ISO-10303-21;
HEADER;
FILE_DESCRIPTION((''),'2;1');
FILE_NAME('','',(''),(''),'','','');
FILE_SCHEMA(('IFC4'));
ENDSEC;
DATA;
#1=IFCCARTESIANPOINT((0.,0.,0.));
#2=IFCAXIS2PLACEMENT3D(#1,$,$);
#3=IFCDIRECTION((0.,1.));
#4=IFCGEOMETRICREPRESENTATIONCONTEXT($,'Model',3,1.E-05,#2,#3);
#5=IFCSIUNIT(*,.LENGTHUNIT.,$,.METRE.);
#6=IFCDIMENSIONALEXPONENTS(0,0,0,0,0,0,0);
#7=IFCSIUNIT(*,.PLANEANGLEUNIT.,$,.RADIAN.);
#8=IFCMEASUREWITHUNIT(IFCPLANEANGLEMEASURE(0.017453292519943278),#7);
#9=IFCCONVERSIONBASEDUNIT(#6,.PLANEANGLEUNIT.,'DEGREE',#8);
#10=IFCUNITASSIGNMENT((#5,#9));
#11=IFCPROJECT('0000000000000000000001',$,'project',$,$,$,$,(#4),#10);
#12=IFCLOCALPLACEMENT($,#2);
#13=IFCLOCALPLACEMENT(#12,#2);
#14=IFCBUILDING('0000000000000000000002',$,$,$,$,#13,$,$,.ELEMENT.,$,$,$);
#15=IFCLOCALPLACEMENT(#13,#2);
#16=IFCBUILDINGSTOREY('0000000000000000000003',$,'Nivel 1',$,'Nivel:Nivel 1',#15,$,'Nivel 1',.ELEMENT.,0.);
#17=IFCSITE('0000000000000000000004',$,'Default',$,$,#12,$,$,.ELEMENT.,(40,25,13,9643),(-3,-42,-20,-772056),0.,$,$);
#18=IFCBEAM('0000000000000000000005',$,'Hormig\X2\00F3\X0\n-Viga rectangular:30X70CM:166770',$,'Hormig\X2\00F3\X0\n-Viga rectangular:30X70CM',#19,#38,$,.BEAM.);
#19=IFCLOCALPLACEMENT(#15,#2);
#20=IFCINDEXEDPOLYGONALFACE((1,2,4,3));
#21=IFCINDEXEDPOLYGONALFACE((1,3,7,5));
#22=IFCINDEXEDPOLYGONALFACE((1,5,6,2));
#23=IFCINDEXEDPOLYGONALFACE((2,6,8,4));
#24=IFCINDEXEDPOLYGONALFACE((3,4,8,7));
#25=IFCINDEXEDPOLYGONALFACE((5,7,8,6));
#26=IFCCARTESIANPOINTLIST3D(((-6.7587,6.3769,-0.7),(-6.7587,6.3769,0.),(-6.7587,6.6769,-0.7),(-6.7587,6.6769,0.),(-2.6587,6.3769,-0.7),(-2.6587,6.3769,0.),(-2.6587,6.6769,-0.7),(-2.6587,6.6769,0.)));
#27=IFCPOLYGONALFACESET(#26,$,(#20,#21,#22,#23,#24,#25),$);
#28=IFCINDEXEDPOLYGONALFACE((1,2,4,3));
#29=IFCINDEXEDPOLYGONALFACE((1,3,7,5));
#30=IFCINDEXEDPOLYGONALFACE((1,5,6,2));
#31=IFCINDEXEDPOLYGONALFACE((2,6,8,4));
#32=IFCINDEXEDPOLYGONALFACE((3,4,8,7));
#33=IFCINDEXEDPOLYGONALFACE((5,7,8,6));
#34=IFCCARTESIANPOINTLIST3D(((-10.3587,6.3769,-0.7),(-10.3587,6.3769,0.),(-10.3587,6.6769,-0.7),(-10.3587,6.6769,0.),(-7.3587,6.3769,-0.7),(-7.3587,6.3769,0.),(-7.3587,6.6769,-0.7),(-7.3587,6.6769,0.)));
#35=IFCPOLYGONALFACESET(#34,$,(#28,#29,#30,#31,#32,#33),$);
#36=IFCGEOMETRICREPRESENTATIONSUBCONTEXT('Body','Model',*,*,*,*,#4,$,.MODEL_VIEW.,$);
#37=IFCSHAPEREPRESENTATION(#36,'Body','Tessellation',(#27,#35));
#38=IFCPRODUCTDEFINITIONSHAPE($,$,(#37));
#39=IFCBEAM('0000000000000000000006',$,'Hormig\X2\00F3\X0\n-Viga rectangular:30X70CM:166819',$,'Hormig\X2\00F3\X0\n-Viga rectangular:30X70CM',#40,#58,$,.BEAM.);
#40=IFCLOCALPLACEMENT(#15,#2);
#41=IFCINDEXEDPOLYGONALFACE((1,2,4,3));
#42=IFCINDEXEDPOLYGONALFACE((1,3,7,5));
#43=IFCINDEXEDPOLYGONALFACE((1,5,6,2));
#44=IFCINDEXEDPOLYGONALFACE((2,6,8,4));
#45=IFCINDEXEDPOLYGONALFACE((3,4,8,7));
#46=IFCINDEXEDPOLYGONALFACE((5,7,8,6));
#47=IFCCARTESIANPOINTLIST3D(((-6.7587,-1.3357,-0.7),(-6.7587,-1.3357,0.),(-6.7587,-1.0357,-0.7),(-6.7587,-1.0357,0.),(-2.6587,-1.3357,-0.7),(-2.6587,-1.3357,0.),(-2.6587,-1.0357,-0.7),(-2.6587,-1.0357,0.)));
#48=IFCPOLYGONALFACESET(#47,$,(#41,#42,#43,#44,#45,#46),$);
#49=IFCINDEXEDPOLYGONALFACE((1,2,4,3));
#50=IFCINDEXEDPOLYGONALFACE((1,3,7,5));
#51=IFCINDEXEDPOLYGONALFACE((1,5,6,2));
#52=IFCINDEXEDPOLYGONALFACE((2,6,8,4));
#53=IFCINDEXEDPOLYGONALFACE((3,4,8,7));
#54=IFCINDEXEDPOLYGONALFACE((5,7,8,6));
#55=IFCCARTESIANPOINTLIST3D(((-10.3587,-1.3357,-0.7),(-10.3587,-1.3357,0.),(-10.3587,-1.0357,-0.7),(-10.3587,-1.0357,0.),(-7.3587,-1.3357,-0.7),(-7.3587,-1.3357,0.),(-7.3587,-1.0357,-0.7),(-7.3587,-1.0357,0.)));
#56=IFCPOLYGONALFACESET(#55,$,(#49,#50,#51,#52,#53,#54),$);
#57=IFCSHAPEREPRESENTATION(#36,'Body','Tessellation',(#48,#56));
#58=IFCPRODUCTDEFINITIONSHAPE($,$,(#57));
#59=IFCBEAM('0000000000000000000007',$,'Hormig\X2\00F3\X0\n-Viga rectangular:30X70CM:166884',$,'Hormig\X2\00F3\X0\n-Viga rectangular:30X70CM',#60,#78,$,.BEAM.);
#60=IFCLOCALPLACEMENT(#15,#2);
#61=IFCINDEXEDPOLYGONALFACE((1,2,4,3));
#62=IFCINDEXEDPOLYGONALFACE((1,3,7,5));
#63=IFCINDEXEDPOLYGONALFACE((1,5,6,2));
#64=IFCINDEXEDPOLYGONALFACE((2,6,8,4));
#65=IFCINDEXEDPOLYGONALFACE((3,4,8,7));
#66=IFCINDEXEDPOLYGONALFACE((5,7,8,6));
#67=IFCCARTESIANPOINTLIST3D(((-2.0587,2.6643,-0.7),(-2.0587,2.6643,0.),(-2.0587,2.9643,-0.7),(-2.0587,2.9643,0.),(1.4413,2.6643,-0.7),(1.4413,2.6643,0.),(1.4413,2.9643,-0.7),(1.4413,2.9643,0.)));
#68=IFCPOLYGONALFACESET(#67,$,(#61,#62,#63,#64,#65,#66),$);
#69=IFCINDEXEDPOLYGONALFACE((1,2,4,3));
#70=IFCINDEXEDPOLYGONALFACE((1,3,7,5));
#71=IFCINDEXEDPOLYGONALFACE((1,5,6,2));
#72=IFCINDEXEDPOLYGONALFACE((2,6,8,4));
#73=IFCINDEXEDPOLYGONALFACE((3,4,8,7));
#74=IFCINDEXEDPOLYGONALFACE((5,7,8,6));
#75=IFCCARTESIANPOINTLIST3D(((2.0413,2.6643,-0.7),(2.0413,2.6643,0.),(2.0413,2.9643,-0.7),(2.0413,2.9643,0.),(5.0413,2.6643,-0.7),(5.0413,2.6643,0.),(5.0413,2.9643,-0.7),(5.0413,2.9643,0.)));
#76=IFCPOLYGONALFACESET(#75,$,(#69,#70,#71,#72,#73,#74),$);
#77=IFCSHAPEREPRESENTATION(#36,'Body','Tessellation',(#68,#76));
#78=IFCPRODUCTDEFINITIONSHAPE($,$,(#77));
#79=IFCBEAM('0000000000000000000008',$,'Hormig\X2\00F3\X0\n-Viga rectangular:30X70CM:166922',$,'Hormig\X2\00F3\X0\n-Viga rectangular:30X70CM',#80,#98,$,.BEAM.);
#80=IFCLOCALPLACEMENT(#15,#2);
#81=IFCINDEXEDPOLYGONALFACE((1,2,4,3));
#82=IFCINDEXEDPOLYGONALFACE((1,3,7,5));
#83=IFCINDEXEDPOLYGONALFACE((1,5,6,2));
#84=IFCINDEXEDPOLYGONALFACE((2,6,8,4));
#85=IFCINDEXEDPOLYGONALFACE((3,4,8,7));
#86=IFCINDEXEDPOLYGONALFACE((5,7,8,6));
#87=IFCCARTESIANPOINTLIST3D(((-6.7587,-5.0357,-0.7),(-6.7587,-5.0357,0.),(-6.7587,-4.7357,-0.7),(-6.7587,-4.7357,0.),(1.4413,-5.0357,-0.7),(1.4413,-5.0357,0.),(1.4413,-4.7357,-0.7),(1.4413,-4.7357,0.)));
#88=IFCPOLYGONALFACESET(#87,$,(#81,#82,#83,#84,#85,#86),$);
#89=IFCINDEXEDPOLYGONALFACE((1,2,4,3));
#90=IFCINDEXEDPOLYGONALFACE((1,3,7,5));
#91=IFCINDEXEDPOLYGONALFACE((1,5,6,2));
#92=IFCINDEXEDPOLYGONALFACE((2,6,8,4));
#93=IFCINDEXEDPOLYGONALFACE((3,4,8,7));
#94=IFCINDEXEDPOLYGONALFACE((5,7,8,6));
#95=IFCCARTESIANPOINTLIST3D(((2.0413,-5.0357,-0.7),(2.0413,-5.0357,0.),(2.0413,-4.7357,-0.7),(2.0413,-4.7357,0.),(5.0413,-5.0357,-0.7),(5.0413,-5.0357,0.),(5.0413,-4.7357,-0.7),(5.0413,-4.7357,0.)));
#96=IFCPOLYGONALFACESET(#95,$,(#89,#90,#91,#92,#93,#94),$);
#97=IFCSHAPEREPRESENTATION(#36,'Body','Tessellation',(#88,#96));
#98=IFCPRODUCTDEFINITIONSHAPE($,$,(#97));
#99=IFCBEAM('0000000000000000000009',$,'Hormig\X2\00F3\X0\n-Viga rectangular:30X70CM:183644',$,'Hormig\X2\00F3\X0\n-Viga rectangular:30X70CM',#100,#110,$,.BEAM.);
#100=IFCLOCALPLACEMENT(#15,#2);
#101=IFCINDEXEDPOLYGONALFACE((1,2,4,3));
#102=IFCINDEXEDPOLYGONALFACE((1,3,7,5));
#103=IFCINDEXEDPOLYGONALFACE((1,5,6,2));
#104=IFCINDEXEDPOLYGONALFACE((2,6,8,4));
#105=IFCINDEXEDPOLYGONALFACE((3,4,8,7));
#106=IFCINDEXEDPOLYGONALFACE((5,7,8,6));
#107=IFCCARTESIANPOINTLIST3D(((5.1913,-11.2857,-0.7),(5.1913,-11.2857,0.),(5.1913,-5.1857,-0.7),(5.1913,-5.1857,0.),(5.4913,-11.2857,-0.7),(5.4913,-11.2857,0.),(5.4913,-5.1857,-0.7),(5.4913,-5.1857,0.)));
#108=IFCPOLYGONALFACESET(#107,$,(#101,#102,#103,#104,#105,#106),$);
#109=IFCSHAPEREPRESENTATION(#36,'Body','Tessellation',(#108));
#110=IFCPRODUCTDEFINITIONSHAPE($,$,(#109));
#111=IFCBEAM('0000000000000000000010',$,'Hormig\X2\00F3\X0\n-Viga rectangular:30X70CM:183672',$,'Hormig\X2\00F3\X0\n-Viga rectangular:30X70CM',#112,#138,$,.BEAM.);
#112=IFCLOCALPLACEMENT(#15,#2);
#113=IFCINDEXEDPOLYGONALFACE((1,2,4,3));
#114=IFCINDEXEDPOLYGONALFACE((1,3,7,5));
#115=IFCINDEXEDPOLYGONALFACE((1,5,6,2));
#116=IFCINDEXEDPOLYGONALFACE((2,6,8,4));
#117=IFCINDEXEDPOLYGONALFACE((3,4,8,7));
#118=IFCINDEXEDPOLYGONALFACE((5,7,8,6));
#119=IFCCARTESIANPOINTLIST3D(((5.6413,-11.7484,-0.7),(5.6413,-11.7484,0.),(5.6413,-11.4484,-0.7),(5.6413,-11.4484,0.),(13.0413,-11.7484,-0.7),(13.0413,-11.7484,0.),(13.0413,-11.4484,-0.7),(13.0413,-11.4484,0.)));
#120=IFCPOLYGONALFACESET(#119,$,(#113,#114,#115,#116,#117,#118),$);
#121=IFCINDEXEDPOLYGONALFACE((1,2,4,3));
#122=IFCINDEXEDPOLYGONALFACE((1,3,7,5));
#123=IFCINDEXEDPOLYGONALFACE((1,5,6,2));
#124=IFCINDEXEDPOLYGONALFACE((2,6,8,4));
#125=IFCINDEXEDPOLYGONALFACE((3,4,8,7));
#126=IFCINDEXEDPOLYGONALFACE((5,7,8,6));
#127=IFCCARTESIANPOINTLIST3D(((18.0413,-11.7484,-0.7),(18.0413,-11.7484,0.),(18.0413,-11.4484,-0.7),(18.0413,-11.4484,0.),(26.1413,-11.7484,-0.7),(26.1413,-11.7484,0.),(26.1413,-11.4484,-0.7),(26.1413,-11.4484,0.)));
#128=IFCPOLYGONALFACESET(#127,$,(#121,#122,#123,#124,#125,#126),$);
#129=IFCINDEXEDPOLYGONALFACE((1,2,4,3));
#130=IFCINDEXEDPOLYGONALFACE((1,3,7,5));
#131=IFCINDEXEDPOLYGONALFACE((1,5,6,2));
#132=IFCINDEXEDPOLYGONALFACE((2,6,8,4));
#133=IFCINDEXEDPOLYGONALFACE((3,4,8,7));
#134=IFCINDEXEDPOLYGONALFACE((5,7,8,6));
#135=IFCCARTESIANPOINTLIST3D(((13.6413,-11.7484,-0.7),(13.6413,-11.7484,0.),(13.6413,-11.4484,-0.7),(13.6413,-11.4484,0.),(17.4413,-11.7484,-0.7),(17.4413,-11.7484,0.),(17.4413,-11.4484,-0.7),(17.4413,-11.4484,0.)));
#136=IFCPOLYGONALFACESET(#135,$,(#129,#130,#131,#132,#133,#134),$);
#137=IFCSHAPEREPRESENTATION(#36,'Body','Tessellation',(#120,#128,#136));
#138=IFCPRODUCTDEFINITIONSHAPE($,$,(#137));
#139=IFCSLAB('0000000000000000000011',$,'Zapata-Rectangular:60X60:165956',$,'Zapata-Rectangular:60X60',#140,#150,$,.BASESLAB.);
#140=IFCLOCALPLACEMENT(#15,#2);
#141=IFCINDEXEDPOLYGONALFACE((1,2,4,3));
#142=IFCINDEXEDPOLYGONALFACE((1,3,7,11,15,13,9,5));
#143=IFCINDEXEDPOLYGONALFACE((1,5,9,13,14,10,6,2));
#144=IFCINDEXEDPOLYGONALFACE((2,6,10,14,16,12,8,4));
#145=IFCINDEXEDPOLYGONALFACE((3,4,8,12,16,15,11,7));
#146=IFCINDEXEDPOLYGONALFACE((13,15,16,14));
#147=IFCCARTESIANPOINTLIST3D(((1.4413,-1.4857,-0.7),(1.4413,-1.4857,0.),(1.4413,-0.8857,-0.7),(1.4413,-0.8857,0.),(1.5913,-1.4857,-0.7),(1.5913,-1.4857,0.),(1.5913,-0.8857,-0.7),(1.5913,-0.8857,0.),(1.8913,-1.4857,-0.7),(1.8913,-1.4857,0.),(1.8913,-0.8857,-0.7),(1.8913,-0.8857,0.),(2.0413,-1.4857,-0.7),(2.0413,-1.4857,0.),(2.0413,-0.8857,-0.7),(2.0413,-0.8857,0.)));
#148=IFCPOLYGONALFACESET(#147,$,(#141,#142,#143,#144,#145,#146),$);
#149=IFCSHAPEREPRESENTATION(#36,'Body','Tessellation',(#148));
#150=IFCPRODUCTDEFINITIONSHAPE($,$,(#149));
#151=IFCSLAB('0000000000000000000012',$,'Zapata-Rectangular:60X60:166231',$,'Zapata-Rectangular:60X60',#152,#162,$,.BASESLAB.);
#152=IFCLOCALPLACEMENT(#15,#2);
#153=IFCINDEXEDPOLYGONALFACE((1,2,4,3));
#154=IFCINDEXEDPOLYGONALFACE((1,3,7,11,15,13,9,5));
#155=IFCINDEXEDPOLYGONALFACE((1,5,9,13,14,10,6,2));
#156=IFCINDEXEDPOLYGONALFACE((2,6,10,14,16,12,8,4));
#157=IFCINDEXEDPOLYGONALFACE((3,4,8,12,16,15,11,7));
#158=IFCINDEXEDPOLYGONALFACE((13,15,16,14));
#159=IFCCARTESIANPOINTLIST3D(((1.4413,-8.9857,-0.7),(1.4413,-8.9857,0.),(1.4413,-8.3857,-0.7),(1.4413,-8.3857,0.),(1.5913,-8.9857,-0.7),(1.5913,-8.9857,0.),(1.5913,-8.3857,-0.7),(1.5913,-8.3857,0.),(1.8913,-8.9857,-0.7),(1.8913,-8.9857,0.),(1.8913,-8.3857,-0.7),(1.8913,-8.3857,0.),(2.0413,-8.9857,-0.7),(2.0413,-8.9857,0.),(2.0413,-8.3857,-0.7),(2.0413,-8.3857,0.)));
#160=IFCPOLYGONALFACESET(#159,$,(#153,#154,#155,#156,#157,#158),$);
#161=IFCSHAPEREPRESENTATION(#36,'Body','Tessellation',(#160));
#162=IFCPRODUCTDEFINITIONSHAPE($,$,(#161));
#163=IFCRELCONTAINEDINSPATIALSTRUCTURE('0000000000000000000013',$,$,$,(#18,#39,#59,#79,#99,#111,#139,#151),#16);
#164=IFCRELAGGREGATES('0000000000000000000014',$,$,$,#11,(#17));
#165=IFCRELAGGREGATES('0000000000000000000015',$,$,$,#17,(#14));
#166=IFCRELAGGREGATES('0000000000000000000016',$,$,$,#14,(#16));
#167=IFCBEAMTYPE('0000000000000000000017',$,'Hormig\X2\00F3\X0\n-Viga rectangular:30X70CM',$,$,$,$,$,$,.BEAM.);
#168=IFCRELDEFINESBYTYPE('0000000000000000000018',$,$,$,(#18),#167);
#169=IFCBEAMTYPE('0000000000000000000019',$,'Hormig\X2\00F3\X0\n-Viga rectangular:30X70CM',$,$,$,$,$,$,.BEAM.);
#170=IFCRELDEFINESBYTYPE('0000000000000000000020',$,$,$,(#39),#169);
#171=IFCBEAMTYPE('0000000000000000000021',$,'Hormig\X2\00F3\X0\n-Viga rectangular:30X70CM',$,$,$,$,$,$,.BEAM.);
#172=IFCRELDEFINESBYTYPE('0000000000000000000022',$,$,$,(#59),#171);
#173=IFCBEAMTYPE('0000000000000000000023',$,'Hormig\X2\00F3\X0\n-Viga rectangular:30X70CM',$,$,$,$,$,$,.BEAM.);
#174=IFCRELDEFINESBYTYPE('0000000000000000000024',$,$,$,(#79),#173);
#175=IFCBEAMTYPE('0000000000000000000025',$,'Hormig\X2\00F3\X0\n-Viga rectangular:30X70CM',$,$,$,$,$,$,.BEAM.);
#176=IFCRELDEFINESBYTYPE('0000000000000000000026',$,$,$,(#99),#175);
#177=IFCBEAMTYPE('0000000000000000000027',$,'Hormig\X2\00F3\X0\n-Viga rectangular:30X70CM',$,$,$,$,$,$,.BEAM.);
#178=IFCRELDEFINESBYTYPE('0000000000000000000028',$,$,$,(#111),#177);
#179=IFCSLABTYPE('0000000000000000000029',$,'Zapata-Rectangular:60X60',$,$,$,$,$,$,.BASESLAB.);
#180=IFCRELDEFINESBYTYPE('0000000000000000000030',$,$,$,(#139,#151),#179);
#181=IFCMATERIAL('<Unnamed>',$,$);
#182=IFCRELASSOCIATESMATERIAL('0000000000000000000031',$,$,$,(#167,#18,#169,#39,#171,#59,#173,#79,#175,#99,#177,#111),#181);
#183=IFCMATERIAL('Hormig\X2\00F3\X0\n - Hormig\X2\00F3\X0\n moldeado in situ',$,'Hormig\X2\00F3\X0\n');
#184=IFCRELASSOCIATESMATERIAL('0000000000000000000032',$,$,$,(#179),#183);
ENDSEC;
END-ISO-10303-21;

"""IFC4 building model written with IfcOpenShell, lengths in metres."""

from ifc_helpers import new_model, entity, si_unit, converted_unit, direction, frame, origin, place, context, subcontext, project, spatial, indexed_curve, outline, extrude, source, transform, mapped, material, type_object, type_shapes, element, save


model = new_model("IFC4")

# Units and contexts
model_context = context("Model", 3, precision=1e-05, world=origin(), true_north=direction((0.0, 1.0)))
body_context = subcontext(model_context, "Body", "Model", "MODEL_VIEW")
ifc_project = project(units=[si_unit("LENGTHUNIT", "METRE"), converted_unit("PLANEANGLEUNIT", "DEGREE", entity("IfcPlaneAngleMeasure", 0.017453292519943278), si_unit("PLANEANGLEUNIT", "RADIAN"), dimensions=[0, 0, 0, 0, 0, 0, 0])], contexts=[model_context])

# Site, building, storey
site_placement = place(None, origin())
site = spatial("IfcSite", under=ifc_project, at=site_placement, Name="Default", CompositionType="ELEMENT", RefLatitude=(40, 25, 13, 9643), RefLongitude=(-3, -42, -20, -772056), RefElevation=0.0)
building_placement = place(site_placement, origin())
building = spatial("IfcBuilding", under=site, at=building_placement, CompositionType="ELEMENT")
storey_placement = place(building_placement, origin())
storey = spatial("IfcBuildingStorey", under=building, at=storey_placement, Name="Nivel 1", ObjectType="Nivel:Nivel 1", LongName="Nivel 1", CompositionType="ELEMENT", Elevation=0.0)

# Beams
ifc_material_1 = material(Name="<Unnamed>")
beam_type_1 = type_object("IfcBeamType", Name="Hormigón-Viga rectangular:30X70CM", PredefinedType="BEAM", material=ifc_material_1)
shared_shape_1 = source(origin(), body_context, "Body", "SweptSolid", [
    extrude(outline(indexed_curve([(-0.35, -0.15), (0.35, -0.15), (0.35, 0.15), (-0.35, 0.15), (-0.35, -0.15)], self_intersect=False)), frame((-6.7587, 6.5269, -0.35), z_axis=(1.0, 0.0, 0.0), x_axis=(0.0, 0.0, -1.0)), (0.0, 0.0, 1.0), 4.1),
    extrude(outline(indexed_curve([(-0.35, -0.15), (0.35, -0.15), (0.35, 0.15), (-0.35, 0.15), (-0.35, -0.15)], self_intersect=False)), frame((-10.3587, 6.5269, -0.35), z_axis=(1.0, 0.0, 0.0), x_axis=(0.0, 0.0, -1.0)), (0.0, 0.0, 1.0), 3.0),
])
type_shapes(beam_type_1, [shared_shape_1])
beam_1_placement = place(storey_placement, origin())
element("IfcBeam", 1, at=beam_1_placement, inside=storey, type_object=beam_type_1, material=ifc_material_1, Name="Hormigón-Viga rectangular:30X70CM:166770", ObjectType="Hormigón-Viga rectangular:30X70CM", PredefinedType="BEAM", context=body_context, shape_type="MappedRepresentation", body=[
    mapped(shared_shape_1, transform((0.0, 0.0, 0.0), scale=1.0)),
])
beam_type_2 = type_object("IfcBeamType", Name="Hormigón-Viga rectangular:30X70CM", PredefinedType="BEAM", material=ifc_material_1)
shared_shape_2 = source(origin(), body_context, "Body", "SweptSolid", [
    extrude(outline(indexed_curve([(-0.35, -0.15), (0.35, -0.15), (0.35, 0.15), (-0.35, 0.15), (-0.35, -0.15)], self_intersect=False)), frame((-6.7587, -1.1857, -0.35), z_axis=(1.0, 0.0, 0.0), x_axis=(0.0, 0.0, -1.0)), (0.0, 0.0, 1.0), 4.1),
    extrude(outline(indexed_curve([(-0.35, -0.15), (0.35, -0.15), (0.35, 0.15), (-0.35, 0.15), (-0.35, -0.15)], self_intersect=False)), frame((-10.3587, -1.1857, -0.35), z_axis=(1.0, 0.0, 0.0), x_axis=(0.0, 0.0, -1.0)), (0.0, 0.0, 1.0), 3.0),
])
type_shapes(beam_type_2, [shared_shape_2])
beam_2_placement = place(storey_placement, origin())
element("IfcBeam", 2, at=beam_2_placement, inside=storey, type_object=beam_type_2, material=ifc_material_1, Name="Hormigón-Viga rectangular:30X70CM:166819", ObjectType="Hormigón-Viga rectangular:30X70CM", PredefinedType="BEAM", context=body_context, shape_type="MappedRepresentation", body=[
    mapped(shared_shape_2, transform((0.0, 0.0, 0.0), scale=1.0)),
])
beam_type_3 = type_object("IfcBeamType", Name="Hormigón-Viga rectangular:30X70CM", PredefinedType="BEAM", material=ifc_material_1)
shared_shape_3 = source(origin(), body_context, "Body", "SweptSolid", [
    extrude(outline(indexed_curve([(-0.35, -0.15), (0.35, -0.15), (0.35, 0.15), (-0.35, 0.15), (-0.35, -0.15)], self_intersect=False)), frame((-2.0587, 2.8143, -0.35), z_axis=(1.0, 0.0, 0.0), x_axis=(0.0, 0.0, -1.0)), (0.0, 0.0, 1.0), 3.5),
    extrude(outline(indexed_curve([(-0.35, -0.15), (0.35, -0.15), (0.35, 0.15), (-0.35, 0.15), (-0.35, -0.15)], self_intersect=False)), frame((2.0413, 2.8143, -0.35), z_axis=(1.0, 0.0, 0.0), x_axis=(0.0, 0.0, -1.0)), (0.0, 0.0, 1.0), 3.0),
])
type_shapes(beam_type_3, [shared_shape_3])
beam_3_placement = place(storey_placement, origin())
element("IfcBeam", 3, at=beam_3_placement, inside=storey, type_object=beam_type_3, material=ifc_material_1, Name="Hormigón-Viga rectangular:30X70CM:166884", ObjectType="Hormigón-Viga rectangular:30X70CM", PredefinedType="BEAM", context=body_context, shape_type="MappedRepresentation", body=[
    mapped(shared_shape_3, transform((0.0, 0.0, 0.0), scale=1.0)),
])
beam_type_4 = type_object("IfcBeamType", Name="Hormigón-Viga rectangular:30X70CM", PredefinedType="BEAM", material=ifc_material_1)
shared_shape_4 = source(origin(), body_context, "Body", "SweptSolid", [
    extrude(outline(indexed_curve([(-0.35, -0.15), (0.35, -0.15), (0.35, 0.15), (-0.35, 0.15), (-0.35, -0.15)], self_intersect=False)), frame((-6.7587, -4.8857, -0.35), z_axis=(1.0, 0.0, 0.0), x_axis=(0.0, 0.0, -1.0)), (0.0, 0.0, 1.0), 8.2),
    extrude(outline(indexed_curve([(-0.35, -0.15), (0.35, -0.15), (0.35, 0.15), (-0.35, 0.15), (-0.35, -0.15)], self_intersect=False)), frame((2.0413, -4.8857, -0.35), z_axis=(1.0, 0.0, 0.0), x_axis=(0.0, 0.0, -1.0)), (0.0, 0.0, 1.0), 3.0),
])
type_shapes(beam_type_4, [shared_shape_4])
beam_4_placement = place(storey_placement, origin())
element("IfcBeam", 4, at=beam_4_placement, inside=storey, type_object=beam_type_4, material=ifc_material_1, Name="Hormigón-Viga rectangular:30X70CM:166922", ObjectType="Hormigón-Viga rectangular:30X70CM", PredefinedType="BEAM", context=body_context, shape_type="MappedRepresentation", body=[
    mapped(shared_shape_4, transform((0.0, 0.0, 0.0), scale=1.0)),
])
beam_type_5 = type_object("IfcBeamType", Name="Hormigón-Viga rectangular:30X70CM", PredefinedType="BEAM", material=ifc_material_1)
shared_shape_5 = source(origin(), body_context, "Body", "SweptSolid", [
    extrude(outline(indexed_curve([(-0.15, -0.35), (0.15, -0.35), (0.15, 0.35), (-0.15, 0.35), (-0.15, -0.35)], self_intersect=False)), frame((5.3413, -5.1857, -0.35), z_axis=(0.0, -1.0, 0.0), x_axis=(-1.0, 0.0, 0.0)), (0.0, 0.0, 1.0), 6.1),
])
type_shapes(beam_type_5, [shared_shape_5])
beam_5_placement = place(storey_placement, origin())
element("IfcBeam", 5, at=beam_5_placement, inside=storey, type_object=beam_type_5, material=ifc_material_1, Name="Hormigón-Viga rectangular:30X70CM:183644", ObjectType="Hormigón-Viga rectangular:30X70CM", PredefinedType="BEAM", context=body_context, shape_type="MappedRepresentation", body=[
    mapped(shared_shape_5, transform((0.0, 0.0, 0.0), scale=1.0)),
])
beam_type_6 = type_object("IfcBeamType", Name="Hormigón-Viga rectangular:30X70CM", PredefinedType="BEAM", material=ifc_material_1)
shared_shape_6 = source(origin(), body_context, "Body", "SweptSolid", [
    extrude(outline(indexed_curve([(-0.35, -0.15), (0.35, -0.15), (0.35, 0.15), (-0.35, 0.15), (-0.35, -0.15)], self_intersect=False)), frame((5.6413, -11.5984, -0.35), z_axis=(1.0, 0.0, 0.0), x_axis=(0.0, 0.0, -1.0)), (0.0, 0.0, 1.0), 7.4),
    extrude(outline(indexed_curve([(-0.35, -0.15), (0.35, -0.15), (0.35, 0.15), (-0.35, 0.15), (-0.35, -0.15)], self_intersect=False)), frame((18.0413, -11.5984, -0.35), z_axis=(1.0, 0.0, 0.0), x_axis=(0.0, 0.0, -1.0)), (0.0, 0.0, 1.0), 8.1),
    extrude(outline(indexed_curve([(-0.35, -0.15), (0.35, -0.15), (0.35, 0.15), (-0.35, 0.15), (-0.35, -0.15)], self_intersect=False)), frame((13.6413, -11.5984, -0.35), z_axis=(1.0, 0.0, 0.0), x_axis=(0.0, 0.0, -1.0)), (0.0, 0.0, 1.0), 3.8),
])
type_shapes(beam_type_6, [shared_shape_6])
beam_6_placement = place(storey_placement, origin())
element("IfcBeam", 6, at=beam_6_placement, inside=storey, type_object=beam_type_6, material=ifc_material_1, Name="Hormigón-Viga rectangular:30X70CM:183672", ObjectType="Hormigón-Viga rectangular:30X70CM", PredefinedType="BEAM", context=body_context, shape_type="MappedRepresentation", body=[
    mapped(shared_shape_6, transform((0.0, 0.0, 0.0), scale=1.0)),
])

# Slabs
ifc_material_2 = material(Name="Hormigón - Hormigón moldeado in situ", Category="Hormigón")
slab_type = type_object("IfcSlabType", Name="Zapata-Rectangular:60X60", PredefinedType="BASESLAB", material=ifc_material_2)
slab_1_placement = place(storey_placement, origin())
element("IfcSlab", 7, at=slab_1_placement, inside=storey, type_object=slab_type, Name="Zapata-Rectangular:60X60:165956", ObjectType="Zapata-Rectangular:60X60", PredefinedType="BASESLAB", context=body_context, shape_type="SweptSolid", body=[
    extrude(outline(indexed_curve([(-0.3, -0.3), (-0.15, -0.3), (0.15, -0.3), (0.3, -0.3), (0.3, 0.3), (0.15, 0.3), (-0.15, 0.3), (-0.3, 0.3), (-0.3, -0.3)], self_intersect=False)), frame((1.7413, -1.1857, -0.7), z_axis=(0.0, 0.0, 1.0), x_axis=(-1.0, 0.0, 0.0)), (0.0, 0.0, 1.0), 0.7),
])
slab_2_placement = place(storey_placement, origin())
element("IfcSlab", 8, at=slab_2_placement, inside=storey, type_object=slab_type, Name="Zapata-Rectangular:60X60:166231", ObjectType="Zapata-Rectangular:60X60", PredefinedType="BASESLAB", context=body_context, shape_type="SweptSolid", body=[
    extrude(outline(indexed_curve([(-0.3, -0.3), (-0.15, -0.3), (0.15, -0.3), (0.3, -0.3), (0.3, 0.3), (0.15, 0.3), (-0.15, 0.3), (-0.3, 0.3), (-0.3, -0.3)], self_intersect=False)), frame((1.7413, -8.6857, -0.7), z_axis=(0.0, 0.0, 1.0), x_axis=(-1.0, 0.0, 0.0)), (0.0, 0.0, 1.0), 0.7),
])

save(model, "model.ifc")
